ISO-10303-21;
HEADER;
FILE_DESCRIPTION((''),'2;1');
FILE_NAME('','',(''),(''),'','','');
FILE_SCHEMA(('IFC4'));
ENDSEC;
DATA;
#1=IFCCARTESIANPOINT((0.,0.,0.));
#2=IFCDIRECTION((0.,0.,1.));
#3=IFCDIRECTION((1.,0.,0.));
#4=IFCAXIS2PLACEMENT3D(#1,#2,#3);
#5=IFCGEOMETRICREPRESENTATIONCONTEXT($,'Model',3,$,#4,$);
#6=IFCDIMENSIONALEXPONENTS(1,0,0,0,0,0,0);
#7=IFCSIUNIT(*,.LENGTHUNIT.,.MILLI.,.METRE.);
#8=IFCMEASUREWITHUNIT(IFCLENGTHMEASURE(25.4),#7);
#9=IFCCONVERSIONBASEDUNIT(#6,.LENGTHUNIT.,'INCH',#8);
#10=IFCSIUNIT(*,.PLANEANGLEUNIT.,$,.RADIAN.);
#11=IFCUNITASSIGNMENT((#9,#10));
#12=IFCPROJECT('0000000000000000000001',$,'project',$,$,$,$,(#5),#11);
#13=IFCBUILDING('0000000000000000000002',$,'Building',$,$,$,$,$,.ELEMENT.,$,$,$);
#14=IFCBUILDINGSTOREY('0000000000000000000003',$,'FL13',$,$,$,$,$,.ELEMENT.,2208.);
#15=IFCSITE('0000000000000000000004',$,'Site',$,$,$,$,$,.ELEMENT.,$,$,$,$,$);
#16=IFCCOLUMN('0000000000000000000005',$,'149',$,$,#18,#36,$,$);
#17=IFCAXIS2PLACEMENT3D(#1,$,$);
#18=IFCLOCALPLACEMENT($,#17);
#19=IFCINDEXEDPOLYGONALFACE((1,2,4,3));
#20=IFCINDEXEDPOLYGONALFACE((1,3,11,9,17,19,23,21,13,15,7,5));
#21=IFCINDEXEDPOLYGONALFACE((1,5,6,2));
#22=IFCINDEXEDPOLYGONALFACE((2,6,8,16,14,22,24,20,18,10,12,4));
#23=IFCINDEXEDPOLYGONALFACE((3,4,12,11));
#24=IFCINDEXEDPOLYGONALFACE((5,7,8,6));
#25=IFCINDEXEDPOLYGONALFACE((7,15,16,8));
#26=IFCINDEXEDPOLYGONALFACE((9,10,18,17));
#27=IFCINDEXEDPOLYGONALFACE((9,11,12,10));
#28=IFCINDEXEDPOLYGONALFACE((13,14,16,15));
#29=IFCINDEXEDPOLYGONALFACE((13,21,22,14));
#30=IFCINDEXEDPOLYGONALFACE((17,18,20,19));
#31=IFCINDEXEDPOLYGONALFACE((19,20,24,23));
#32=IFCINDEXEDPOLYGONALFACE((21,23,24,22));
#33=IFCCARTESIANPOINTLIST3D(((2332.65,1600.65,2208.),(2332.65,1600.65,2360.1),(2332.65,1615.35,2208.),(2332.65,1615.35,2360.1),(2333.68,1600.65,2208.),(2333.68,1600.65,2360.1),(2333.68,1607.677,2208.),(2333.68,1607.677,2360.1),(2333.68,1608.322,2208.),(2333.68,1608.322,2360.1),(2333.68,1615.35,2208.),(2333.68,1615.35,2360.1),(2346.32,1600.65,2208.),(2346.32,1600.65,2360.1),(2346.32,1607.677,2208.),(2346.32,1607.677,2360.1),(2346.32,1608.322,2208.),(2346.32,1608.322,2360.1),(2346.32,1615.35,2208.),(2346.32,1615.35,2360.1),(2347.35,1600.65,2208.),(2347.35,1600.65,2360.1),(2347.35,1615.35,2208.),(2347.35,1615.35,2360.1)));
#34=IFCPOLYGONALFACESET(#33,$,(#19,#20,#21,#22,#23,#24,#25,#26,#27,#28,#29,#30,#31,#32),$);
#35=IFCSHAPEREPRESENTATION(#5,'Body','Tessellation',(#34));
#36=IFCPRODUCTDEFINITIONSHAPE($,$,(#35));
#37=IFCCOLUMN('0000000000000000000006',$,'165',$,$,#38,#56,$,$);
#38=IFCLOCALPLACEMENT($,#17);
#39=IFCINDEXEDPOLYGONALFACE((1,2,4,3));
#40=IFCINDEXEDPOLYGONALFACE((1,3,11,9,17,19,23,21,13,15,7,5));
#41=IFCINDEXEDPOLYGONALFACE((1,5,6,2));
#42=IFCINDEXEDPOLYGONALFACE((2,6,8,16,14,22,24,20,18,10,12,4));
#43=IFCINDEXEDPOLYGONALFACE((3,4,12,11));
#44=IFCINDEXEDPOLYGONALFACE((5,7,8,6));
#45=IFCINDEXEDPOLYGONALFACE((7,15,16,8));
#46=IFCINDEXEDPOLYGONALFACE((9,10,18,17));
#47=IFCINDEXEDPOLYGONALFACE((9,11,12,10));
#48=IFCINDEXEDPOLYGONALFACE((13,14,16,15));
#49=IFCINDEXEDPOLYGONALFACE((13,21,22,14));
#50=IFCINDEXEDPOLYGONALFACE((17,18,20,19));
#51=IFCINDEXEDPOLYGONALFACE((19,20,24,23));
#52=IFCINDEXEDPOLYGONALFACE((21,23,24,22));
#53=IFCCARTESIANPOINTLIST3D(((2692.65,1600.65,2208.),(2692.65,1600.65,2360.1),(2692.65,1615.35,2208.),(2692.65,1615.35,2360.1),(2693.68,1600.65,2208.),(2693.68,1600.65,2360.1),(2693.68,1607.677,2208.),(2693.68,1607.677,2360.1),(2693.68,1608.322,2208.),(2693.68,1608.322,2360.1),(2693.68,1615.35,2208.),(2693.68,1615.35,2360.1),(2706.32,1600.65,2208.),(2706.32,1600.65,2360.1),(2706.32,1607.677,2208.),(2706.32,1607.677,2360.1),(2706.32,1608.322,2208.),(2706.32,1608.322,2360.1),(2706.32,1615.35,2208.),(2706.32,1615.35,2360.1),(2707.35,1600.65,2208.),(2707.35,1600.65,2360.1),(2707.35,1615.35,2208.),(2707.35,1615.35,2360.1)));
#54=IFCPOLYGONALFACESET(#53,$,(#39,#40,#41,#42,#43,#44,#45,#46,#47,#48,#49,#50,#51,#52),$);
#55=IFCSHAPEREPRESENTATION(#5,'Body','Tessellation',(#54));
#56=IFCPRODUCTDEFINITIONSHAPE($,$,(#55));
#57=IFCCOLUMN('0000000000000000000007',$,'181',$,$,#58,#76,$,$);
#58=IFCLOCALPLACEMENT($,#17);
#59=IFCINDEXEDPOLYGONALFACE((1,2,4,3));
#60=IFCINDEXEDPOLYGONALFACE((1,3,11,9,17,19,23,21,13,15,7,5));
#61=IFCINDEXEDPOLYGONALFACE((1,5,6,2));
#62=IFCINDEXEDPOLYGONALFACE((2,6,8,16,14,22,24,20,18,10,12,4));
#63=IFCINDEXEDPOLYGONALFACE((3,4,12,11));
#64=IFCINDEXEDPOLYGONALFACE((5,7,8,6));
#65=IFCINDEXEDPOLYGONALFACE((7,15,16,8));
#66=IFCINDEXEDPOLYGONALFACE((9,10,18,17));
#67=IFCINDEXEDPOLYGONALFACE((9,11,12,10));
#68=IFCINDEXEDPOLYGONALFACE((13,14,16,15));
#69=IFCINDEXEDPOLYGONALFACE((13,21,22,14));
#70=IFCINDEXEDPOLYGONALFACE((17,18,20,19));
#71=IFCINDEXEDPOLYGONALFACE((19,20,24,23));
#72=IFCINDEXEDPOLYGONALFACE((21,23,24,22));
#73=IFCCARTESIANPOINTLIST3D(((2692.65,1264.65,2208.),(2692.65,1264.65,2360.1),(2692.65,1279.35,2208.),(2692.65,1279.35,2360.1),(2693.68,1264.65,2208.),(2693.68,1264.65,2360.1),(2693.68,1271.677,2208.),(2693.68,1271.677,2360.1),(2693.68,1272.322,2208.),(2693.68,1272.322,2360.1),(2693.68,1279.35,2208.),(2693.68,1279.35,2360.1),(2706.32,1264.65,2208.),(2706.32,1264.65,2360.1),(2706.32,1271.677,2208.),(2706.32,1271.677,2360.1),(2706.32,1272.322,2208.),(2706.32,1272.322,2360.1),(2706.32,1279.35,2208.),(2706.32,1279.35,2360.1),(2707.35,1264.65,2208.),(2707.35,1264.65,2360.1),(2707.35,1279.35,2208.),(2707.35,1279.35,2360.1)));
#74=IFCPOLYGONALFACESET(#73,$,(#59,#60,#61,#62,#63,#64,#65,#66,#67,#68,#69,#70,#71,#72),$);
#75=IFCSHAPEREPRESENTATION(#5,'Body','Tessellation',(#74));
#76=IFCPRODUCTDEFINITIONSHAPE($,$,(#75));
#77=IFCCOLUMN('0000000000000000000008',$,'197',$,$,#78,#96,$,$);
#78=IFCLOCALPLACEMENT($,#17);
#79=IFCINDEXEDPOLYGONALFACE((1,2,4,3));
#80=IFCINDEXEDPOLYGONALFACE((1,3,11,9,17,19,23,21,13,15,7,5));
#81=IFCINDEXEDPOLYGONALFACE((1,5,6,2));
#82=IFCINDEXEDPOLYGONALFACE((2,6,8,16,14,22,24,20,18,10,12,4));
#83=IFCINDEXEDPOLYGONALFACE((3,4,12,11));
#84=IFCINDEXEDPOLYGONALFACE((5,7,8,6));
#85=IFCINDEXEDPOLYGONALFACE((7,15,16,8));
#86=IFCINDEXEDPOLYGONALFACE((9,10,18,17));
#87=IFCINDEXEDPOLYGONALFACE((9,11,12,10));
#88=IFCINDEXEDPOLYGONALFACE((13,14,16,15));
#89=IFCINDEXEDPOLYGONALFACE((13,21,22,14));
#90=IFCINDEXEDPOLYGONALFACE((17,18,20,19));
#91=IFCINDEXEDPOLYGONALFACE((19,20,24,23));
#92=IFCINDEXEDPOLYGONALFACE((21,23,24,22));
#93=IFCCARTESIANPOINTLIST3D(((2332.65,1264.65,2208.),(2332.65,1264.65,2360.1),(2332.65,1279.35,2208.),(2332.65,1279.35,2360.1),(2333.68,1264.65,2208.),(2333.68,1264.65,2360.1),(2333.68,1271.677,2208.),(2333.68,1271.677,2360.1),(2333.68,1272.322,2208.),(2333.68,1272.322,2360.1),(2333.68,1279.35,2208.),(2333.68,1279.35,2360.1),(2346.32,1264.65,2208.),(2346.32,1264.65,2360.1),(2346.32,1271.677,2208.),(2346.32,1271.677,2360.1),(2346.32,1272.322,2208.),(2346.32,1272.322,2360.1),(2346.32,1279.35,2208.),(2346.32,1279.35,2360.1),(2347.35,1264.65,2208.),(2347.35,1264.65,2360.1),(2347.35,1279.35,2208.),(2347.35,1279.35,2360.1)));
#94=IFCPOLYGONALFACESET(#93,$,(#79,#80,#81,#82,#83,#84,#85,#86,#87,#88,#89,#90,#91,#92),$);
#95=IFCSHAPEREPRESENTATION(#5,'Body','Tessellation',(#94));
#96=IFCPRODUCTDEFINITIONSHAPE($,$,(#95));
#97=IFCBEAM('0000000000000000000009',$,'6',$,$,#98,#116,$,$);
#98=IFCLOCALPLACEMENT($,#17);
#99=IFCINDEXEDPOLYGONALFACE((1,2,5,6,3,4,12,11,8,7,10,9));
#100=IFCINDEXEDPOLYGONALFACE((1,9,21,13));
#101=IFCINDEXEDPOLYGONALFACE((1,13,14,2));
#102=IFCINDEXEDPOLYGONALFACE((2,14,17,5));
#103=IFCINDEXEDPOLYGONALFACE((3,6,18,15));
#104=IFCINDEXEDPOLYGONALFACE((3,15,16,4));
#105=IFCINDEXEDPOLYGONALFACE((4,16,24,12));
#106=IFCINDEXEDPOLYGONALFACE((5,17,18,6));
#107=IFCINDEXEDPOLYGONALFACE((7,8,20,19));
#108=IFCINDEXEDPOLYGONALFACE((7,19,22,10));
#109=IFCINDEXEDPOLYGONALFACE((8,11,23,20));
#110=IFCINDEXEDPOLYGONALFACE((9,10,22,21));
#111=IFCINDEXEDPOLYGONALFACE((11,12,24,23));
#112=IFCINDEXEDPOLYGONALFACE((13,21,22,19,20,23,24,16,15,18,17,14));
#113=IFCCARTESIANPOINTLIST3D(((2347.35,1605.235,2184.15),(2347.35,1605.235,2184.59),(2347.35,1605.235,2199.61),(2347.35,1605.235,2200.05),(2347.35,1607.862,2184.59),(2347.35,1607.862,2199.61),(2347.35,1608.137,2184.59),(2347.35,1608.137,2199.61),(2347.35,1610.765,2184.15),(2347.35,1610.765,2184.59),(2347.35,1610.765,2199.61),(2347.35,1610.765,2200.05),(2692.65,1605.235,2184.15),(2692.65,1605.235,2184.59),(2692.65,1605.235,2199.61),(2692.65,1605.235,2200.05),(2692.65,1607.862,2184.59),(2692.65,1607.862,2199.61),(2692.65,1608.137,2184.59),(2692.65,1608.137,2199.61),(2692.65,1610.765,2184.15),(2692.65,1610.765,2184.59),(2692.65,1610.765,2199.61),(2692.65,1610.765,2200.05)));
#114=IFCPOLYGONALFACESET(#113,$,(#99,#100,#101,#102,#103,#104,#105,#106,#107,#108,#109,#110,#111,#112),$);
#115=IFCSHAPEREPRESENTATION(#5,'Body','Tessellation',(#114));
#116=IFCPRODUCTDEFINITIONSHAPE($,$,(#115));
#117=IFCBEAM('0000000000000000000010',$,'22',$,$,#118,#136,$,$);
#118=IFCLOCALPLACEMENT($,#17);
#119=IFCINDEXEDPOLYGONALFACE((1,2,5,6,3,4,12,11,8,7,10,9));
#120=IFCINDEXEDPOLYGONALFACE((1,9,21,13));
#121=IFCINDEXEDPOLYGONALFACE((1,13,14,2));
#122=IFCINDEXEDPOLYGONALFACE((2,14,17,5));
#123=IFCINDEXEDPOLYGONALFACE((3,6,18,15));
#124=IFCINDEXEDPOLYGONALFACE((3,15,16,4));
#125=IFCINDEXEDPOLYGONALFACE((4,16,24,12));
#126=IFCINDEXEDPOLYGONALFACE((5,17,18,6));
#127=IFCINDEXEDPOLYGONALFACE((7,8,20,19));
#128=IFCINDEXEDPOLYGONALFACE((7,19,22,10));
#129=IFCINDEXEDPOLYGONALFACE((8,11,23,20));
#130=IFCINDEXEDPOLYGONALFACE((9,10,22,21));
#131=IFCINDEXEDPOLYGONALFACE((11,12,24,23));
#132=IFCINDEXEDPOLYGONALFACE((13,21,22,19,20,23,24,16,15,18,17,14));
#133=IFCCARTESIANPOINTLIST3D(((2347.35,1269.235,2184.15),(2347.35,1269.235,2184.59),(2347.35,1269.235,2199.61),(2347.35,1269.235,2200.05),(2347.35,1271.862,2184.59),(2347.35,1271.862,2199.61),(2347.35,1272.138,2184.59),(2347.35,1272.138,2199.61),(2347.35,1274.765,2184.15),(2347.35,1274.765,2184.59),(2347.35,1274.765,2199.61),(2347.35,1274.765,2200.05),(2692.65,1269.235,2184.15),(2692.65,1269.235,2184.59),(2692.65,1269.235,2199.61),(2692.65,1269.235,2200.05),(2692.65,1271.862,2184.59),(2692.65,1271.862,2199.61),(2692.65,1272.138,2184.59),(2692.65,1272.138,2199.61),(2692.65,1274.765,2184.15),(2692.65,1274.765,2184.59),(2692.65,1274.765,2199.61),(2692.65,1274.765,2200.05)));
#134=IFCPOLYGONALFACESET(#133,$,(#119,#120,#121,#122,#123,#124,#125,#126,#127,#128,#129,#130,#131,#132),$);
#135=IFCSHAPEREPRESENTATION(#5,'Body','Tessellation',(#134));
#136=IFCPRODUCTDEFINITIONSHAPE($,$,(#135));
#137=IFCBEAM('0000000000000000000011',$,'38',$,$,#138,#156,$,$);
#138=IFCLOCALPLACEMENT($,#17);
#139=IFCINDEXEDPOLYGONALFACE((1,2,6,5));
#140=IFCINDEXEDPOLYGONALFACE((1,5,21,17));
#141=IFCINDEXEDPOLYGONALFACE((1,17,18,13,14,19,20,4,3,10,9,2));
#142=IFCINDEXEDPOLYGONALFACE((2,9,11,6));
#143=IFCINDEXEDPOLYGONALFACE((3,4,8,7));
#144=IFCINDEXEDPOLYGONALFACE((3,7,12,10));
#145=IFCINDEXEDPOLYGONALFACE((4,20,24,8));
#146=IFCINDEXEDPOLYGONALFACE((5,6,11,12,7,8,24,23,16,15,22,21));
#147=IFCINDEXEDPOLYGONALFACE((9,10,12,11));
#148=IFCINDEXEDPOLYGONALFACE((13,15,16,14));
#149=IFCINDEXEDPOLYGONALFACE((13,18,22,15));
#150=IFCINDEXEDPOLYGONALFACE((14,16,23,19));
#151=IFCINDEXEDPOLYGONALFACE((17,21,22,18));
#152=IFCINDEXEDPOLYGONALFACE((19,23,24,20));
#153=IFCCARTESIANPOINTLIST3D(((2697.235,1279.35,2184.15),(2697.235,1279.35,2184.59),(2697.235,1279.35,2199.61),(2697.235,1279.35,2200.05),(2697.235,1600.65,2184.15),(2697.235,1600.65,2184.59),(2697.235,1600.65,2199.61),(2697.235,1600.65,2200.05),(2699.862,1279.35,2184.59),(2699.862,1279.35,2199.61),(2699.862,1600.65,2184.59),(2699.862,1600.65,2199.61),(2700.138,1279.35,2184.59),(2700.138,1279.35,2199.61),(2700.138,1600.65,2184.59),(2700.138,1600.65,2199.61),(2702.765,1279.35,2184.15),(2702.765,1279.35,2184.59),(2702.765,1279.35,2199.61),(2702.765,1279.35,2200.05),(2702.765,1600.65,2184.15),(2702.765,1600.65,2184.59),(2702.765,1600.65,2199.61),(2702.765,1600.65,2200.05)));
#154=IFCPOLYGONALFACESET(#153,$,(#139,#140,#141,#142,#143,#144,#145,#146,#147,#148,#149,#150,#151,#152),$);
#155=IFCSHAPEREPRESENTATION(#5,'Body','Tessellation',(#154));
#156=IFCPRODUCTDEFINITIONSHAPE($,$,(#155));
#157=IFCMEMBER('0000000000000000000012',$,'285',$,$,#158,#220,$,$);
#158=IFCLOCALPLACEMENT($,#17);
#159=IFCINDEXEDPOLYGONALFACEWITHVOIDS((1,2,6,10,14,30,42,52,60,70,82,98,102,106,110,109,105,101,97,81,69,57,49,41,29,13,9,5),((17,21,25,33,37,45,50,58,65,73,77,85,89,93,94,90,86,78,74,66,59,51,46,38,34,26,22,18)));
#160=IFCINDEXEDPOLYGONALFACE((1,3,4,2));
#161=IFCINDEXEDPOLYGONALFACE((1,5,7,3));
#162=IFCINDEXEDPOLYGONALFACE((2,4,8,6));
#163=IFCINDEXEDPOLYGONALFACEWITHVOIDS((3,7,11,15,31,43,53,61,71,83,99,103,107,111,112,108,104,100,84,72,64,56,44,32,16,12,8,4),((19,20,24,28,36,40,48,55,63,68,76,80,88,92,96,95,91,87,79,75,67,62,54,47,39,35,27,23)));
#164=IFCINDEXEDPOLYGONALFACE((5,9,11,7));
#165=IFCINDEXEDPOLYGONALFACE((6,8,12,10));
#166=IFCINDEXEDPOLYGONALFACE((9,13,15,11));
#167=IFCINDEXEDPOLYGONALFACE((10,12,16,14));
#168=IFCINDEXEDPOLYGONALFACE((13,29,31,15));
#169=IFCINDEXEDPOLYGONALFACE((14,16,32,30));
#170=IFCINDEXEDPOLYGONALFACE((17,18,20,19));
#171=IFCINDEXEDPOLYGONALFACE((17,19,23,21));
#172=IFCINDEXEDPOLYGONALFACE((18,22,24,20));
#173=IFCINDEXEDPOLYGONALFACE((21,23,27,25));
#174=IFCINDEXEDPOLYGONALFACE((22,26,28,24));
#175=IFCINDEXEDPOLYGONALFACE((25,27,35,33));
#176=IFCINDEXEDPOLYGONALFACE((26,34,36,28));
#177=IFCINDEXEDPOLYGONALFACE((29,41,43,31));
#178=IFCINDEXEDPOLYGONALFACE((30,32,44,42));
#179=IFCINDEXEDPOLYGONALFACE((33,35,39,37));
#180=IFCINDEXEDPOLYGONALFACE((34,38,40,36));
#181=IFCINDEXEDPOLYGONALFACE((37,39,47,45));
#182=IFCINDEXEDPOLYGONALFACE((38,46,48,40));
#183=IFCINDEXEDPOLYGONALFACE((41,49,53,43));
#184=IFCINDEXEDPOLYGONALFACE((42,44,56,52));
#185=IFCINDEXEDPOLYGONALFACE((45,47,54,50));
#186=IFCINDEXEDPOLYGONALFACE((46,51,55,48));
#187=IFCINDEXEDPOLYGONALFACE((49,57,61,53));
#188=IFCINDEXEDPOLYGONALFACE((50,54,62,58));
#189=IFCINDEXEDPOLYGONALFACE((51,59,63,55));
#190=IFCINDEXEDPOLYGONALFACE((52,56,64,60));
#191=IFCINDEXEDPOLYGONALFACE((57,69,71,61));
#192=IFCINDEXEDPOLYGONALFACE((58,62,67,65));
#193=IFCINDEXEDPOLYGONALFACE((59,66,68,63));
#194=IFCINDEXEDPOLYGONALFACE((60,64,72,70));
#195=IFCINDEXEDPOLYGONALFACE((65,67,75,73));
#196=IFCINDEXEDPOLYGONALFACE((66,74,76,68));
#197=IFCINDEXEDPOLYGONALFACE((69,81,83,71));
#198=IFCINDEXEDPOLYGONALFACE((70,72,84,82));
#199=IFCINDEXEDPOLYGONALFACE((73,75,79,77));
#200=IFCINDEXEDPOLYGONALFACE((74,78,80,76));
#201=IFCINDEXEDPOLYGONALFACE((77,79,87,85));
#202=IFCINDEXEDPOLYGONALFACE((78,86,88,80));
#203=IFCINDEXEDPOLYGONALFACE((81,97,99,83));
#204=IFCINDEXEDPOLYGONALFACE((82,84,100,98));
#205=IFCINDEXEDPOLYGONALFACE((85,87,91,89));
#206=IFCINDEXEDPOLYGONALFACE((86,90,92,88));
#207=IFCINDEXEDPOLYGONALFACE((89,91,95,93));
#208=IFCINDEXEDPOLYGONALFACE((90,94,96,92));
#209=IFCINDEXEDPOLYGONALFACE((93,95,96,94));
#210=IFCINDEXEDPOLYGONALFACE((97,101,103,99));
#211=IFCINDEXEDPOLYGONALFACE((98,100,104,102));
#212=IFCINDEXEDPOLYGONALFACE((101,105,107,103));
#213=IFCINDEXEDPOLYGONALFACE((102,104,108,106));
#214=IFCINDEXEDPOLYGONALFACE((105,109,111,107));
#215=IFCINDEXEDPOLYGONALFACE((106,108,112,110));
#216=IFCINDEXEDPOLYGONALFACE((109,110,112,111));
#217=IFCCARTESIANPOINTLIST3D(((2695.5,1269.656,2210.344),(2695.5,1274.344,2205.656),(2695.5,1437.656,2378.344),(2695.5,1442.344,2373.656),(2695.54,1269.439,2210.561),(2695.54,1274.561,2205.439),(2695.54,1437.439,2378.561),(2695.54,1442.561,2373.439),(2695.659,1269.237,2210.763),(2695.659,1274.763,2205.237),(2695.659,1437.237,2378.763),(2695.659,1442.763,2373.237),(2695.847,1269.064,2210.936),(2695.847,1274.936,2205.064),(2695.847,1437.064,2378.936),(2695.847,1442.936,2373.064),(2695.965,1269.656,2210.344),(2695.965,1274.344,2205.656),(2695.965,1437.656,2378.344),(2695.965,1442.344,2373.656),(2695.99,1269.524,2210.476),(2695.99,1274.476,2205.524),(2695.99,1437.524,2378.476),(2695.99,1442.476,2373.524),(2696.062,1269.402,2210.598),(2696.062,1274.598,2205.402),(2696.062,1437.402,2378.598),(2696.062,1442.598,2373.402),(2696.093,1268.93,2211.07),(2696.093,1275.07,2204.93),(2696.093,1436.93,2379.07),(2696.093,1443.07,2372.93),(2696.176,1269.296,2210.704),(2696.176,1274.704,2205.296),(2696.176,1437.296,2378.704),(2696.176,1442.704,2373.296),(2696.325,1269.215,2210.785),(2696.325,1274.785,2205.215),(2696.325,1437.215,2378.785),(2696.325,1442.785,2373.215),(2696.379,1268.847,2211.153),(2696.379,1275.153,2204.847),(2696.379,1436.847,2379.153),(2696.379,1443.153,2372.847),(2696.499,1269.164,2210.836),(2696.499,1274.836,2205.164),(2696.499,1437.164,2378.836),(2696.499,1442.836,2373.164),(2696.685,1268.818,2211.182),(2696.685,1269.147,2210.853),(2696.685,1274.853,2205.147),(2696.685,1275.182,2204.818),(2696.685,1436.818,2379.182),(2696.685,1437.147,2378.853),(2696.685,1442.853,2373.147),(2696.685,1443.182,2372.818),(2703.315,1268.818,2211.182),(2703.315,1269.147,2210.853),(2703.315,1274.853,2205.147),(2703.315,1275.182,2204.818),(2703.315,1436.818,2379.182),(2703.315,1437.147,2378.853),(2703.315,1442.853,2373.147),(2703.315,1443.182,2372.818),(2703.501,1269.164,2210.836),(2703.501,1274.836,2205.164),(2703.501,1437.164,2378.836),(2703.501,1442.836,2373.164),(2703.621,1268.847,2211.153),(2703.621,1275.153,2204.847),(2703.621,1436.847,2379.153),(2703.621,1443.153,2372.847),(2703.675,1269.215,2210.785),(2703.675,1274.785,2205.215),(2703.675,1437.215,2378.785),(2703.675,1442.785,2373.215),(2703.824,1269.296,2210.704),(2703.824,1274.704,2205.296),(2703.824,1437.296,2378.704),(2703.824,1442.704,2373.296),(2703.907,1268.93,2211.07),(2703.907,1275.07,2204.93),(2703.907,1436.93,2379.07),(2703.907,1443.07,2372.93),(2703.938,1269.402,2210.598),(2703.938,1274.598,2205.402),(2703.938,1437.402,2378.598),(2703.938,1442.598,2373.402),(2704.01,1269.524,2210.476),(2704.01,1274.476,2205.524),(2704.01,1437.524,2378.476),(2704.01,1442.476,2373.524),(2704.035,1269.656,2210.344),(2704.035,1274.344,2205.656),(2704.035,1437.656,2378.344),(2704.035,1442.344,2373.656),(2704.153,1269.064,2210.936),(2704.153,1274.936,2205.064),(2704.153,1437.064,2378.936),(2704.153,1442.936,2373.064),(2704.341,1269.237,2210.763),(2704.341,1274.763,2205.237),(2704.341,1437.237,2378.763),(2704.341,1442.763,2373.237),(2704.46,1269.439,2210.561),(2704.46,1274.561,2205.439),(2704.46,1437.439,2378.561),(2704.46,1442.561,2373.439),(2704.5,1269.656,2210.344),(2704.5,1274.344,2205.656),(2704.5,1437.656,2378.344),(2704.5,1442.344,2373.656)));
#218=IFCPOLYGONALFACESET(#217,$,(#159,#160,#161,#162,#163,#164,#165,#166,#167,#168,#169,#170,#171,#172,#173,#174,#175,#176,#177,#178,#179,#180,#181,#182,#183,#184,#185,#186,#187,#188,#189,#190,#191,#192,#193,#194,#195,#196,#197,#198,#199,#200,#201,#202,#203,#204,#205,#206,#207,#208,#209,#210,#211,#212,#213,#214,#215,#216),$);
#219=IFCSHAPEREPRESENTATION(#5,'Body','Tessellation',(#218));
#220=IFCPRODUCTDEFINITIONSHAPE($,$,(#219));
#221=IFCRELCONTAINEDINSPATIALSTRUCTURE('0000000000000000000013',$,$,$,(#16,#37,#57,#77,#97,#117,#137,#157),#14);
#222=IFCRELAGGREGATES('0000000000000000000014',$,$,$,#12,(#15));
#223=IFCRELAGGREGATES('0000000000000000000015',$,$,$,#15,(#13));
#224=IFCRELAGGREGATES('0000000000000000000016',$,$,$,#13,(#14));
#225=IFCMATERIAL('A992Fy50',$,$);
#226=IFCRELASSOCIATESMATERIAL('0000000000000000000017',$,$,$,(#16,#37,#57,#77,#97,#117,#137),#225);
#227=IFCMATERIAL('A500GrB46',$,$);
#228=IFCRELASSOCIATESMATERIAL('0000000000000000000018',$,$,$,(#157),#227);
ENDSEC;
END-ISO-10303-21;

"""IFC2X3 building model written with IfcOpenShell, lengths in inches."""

from ifc_helpers import new_model, entity, si_unit, converted_unit, frame, origin_with_axes, origin_2d_with_axis, place, context, project, spatial, hollow_rectangle, i_section, transform_2d, derived_profile, extrude, material, element, save


model = new_model("IFC2X3")

# Units and contexts
model_context = context("Model", 3, world=origin_with_axes())
ifc_project = project(units=[converted_unit("LENGTHUNIT", "INCH", entity("IfcLengthMeasure", 25.4), si_unit("LENGTHUNIT", "METRE", prefix="MILLI"), dimensions=[1, 0, 0, 0, 0, 0, 0]), si_unit("PLANEANGLEUNIT", "RADIAN")], contexts=[model_context])

# Site, building, storey
site = spatial("IfcSite", under=ifc_project, Name="Site", CompositionType="ELEMENT")
building = spatial("IfcBuilding", under=site, Name="Building", CompositionType="ELEMENT")
storey = spatial("IfcBuildingStorey", under=building, Name="FL13", CompositionType="ELEMENT", Elevation=2208.0)

# Columns
ifc_material_1 = material(Name="A992Fy50")
for number, where, z_axis, x_axis, name in (
    (1, (2340.0, 1608.0, 2208.0), (0.0, 0.0, 1.0), (0.0, -1.0, 0.0), "149"),
    (2, (2700.0, 1608.0, 2208.0), (0.0, 0.0, 1.0), (0.0, -1.0, 0.0), "165"),
    (3, (2700.0, 1272.0, 2208.0), (0.0, 0.0, 1.0), (0.0, -1.0, 0.0), "181"),
    (4, (2340.0, 1272.0, 2208.0), (0.0, 0.0, 1.0), (0.0, -1.0, 0.0), "197"),
):
    element("IfcColumn", number, at=place(None, frame(where, z_axis=z_axis, x_axis=x_axis)), inside=storey, material=ifc_material_1, Name=name, context=model_context, shape_type="SweptSolid", body=[
        extrude(i_section(OverallWidth=14.7, OverallDepth=14.7, WebThickness=0.645, FlangeThickness=1.03, at=origin_2d_with_axis()), origin_with_axes(), (0.0, 0.0, 1.0), 152.1),
    ])

# Beams
for number, where, z_axis, x_axis, name in (
    (5, (2347.35, 1608.0, 2208.0), (1.0, 0.0, 0.0), (0.0, 1.0, 0.0), "6"),
    (6, (2347.35, 1272.0, 2208.0), (1.0, 0.0, 0.0), (0.0, 1.0, 0.0), "22"),
):
    element("IfcBeam", number, at=place(None, frame(where, z_axis=z_axis, x_axis=x_axis)), inside=storey, material=ifc_material_1, Name=name, context=model_context, shape_type="SweptSolid", body=[
        extrude(derived_profile(i_section(OverallWidth=5.53, OverallDepth=15.9, WebThickness=0.275, FlangeThickness=0.44, at=origin_2d_with_axis()), transform_2d((0.0, -7.95))), origin_with_axes(), (0.0, 0.0, 1.0), 345.3),
    ])
beam_placement = place(None, frame((2700.0, 1279.35, 2208.0), z_axis=(0.0, 1.0, 0.0), x_axis=(-1.0, 0.0, 0.0)))
element("IfcBeam", 7, at=beam_placement, inside=storey, material=ifc_material_1, Name="38", context=model_context, shape_type="SweptSolid", body=[
    extrude(derived_profile(i_section(OverallWidth=5.53, OverallDepth=15.9, WebThickness=0.275, FlangeThickness=0.44, at=origin_2d_with_axis()), transform_2d((0.0, -7.95))), origin_with_axes(), (0.0, 0.0, 1.0), 321.3),
])

# Member
ifc_material_2 = material(Name="A500GrB46")
for number, where, z_axis, x_axis, name in (
    (8, (2700.0, 1272.0, 2208.0), (0.0, 0.707107, 0.707107), (-1.0, 0.0, 0.0), "285"),
):
    element("IfcMember", number, at=place(None, frame(where, z_axis=z_axis, x_axis=x_axis)), inside=storey, material=ifc_material_2, Name=name, context=model_context, shape_type="SweptSolid", body=[
        extrude(hollow_rectangle(XDim=9.0, YDim=9.0, WallThickness=0.465, InnerFilletRadius=0.72, OuterFilletRadius=1.185, at=origin_2d_with_axis()), origin_with_axes(), (0.0, 0.0, 1.0), 237.588),
    ])

save(model, "model.ifc")
